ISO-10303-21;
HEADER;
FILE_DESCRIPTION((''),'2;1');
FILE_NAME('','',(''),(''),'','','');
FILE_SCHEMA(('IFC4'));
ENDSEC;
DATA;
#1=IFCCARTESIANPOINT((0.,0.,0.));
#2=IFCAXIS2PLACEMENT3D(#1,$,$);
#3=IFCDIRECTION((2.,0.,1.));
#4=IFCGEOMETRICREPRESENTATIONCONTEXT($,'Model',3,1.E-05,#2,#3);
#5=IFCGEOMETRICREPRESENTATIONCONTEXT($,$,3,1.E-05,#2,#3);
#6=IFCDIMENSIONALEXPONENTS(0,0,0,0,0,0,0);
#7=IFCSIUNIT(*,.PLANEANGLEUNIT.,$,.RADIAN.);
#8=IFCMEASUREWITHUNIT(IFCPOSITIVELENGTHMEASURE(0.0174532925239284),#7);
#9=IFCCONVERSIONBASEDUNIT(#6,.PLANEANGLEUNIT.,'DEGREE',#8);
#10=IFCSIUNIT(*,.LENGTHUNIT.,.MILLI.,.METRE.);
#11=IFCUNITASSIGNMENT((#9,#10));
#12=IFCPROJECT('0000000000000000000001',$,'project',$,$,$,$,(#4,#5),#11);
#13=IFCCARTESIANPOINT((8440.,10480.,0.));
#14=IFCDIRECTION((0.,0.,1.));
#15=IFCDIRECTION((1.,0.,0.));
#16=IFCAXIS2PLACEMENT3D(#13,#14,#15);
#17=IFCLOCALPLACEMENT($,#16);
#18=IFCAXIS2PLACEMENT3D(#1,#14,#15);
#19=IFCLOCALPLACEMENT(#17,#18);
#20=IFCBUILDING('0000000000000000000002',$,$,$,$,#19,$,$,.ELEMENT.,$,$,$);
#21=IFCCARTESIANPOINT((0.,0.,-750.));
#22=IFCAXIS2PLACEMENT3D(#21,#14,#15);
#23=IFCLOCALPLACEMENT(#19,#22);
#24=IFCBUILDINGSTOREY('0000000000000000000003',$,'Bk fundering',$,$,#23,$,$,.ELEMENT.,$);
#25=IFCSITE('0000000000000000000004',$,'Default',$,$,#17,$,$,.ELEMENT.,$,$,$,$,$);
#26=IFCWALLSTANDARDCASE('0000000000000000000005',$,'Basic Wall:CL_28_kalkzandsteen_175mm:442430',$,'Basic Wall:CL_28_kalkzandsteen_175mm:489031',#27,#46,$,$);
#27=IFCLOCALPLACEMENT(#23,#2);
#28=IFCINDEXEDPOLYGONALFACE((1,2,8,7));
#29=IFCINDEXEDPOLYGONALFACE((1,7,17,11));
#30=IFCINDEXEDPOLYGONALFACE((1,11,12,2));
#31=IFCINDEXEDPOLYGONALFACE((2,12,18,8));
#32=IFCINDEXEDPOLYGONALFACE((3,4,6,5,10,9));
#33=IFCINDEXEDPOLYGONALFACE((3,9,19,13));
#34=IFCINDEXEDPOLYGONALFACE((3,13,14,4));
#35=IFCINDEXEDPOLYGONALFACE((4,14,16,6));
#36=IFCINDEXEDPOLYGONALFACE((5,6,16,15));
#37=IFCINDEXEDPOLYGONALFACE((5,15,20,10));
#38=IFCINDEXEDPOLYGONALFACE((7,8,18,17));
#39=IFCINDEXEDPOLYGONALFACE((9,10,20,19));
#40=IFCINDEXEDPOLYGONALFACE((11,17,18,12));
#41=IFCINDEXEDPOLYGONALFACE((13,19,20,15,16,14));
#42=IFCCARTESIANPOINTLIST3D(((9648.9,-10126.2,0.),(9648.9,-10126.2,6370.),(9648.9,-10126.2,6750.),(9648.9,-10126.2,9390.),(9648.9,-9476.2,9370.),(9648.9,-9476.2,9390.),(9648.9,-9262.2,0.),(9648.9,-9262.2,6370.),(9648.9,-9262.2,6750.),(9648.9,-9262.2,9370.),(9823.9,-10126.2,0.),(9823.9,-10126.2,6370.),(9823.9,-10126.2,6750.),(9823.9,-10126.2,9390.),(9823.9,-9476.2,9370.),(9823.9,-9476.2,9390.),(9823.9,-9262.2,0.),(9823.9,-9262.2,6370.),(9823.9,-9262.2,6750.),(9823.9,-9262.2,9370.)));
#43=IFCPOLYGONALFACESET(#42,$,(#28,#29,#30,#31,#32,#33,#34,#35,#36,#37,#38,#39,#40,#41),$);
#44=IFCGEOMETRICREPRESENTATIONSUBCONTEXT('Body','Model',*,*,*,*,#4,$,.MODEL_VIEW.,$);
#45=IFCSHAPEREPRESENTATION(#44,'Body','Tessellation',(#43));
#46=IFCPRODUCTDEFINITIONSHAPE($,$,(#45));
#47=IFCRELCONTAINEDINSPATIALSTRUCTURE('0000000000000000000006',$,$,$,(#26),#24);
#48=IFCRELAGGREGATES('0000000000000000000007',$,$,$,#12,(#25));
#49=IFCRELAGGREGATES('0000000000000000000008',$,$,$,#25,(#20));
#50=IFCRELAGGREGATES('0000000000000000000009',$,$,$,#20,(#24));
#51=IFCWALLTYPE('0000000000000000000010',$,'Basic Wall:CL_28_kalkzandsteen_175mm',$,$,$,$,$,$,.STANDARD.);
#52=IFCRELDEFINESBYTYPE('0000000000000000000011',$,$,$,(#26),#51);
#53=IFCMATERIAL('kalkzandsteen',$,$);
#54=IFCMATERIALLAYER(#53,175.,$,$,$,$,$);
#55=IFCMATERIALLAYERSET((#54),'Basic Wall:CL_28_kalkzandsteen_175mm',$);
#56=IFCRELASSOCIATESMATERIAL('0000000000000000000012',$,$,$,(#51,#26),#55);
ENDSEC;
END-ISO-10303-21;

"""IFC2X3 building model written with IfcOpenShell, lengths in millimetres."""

from ifc_helpers import new_model, entity, si_unit, converted_unit, direction, frame, frame_2d, origin, origin_with_axes, place, context, subcontext, project, spatial, polyline, rectangle, extrude, clip, bounded_halfspace, material, layer, layer_set, layer_usage, type_object, element, save


model = new_model("IFC2X3")

# Units and contexts
model_context = context("Model", 3, precision=1e-05, world=origin(), true_north=direction((2.0, 0.0, 1.0)))
context_of_model = context(None, 3, precision=1e-05, world=origin(), true_north=direction((2.0, 0.0, 1.0)))
body_context = subcontext(model_context, "Body", "Model", "MODEL_VIEW")
ifc_project = project(units=[converted_unit("PLANEANGLEUNIT", "DEGREE", entity("IfcPositiveLengthMeasure", 0.0174532925239284), si_unit("PLANEANGLEUNIT", "RADIAN"), dimensions=[0, 0, 0, 0, 0, 0, 0]), si_unit("LENGTHUNIT", "METRE", prefix="MILLI")], contexts=[model_context, context_of_model])

# Site, building, storey
site_placement = place(None, frame((8440.0, 10480.0, 0.0), z_axis=(0.0, 0.0, 1.0), x_axis=(1.0, 0.0, 0.0)))
site = spatial("IfcSite", under=ifc_project, at=site_placement, Name="Default", CompositionType="ELEMENT")
building_placement = place(site_placement, origin_with_axes())
building = spatial("IfcBuilding", under=site, at=building_placement, CompositionType="ELEMENT")
storey_placement = place(building_placement, frame((0.0, 0.0, -750.0), z_axis=(0.0, 0.0, 1.0), x_axis=(1.0, 0.0, 0.0)))
storey = spatial("IfcBuildingStorey", under=building, at=storey_placement, Name="Bk fundering", CompositionType="ELEMENT")

# Shared definitions
ifc_material_1 = material(Name="kalkzandsteen")

# Wall, opening
ifc_layer_1 = layer(ifc_material_1, 175.0)
ifc_layer_set_1 = layer_set([ifc_layer_1], Name="Basic Wall:CL_28_kalkzandsteen_175mm")
wall_type_1 = type_object("IfcWallType", Name="Basic Wall:CL_28_kalkzandsteen_175mm", PredefinedType="STANDARD", material=ifc_layer_set_1)
ifc_layer_usage_1 = layer_usage(ifc_layer_set_1, "AXIS2", "POSITIVE", -87.5)
wall_1_placement = place(storey_placement, frame((9736.4, -9262.2, 0.0), z_axis=(0.0, 0.0, 1.0), x_axis=(0.0, -1.0, 0.0)))
wall_1 = element("IfcWallStandardCase", 1, at=wall_1_placement, inside=storey, type_object=wall_type_1, material=ifc_layer_usage_1, Name="Basic Wall:CL_28_kalkzandsteen_175mm:442430", ObjectType="Basic Wall:CL_28_kalkzandsteen_175mm:489031", context=body_context, shape_type="Clipping", body=[
    clip(clip(extrude(rectangle(XDim=864.0, YDim=175.0, at=frame_2d((432.0, 0.0), x_axis=(-1.0, 0.0))), origin(), (0.0, 0.0, 1.0), 9390.0), bounded_halfspace(frame((214.0, -87.5, 9370.0), z_axis=(0.0, 0.0, -1.0), x_axis=(0.0, 1.0, 0.0)), True, frame((214.0, -87.5, 9370.0), z_axis=(0.0, 0.0, -1.0), x_axis=(0.0, 1.0, 0.0)), polyline([(0.0, 0.0), (0.0, -214.0), (175.0, -214.0), (175.0, 0.0), (0.0, 0.0)]))), bounded_halfspace(frame((214.0, 87.5, 9370.0), z_axis=(1.0, 0.0, 0.0), x_axis=(0.0, 0.0, 1.0)), True, frame((214.0, 87.5, 9370.0), z_axis=(1.0, 0.0, 0.0), x_axis=(0.0, 0.0, 1.0)), polyline([(0.0, 0.0), (20.0, 0.0), (20.0, 175.0), (0.0, 175.0), (0.0, 0.0)]))),
])
opening_1_placement = place(wall_1_placement, origin_with_axes())
element("IfcOpeningElement", 2, at=opening_1_placement, cuts=wall_1, ObjectType="Opening", context=body_context, shape_type="SweptSolid", body=[
    extrude(rectangle(XDim=864.0, YDim=175.0, at=frame_2d((43.6, -17.5), x_axis=(1.0, 0.0))), frame((388.4, 17.5, 6370.0)), (0.0, 0.0, 1.0), 380.0),
])

save(model, "model.ifc")
